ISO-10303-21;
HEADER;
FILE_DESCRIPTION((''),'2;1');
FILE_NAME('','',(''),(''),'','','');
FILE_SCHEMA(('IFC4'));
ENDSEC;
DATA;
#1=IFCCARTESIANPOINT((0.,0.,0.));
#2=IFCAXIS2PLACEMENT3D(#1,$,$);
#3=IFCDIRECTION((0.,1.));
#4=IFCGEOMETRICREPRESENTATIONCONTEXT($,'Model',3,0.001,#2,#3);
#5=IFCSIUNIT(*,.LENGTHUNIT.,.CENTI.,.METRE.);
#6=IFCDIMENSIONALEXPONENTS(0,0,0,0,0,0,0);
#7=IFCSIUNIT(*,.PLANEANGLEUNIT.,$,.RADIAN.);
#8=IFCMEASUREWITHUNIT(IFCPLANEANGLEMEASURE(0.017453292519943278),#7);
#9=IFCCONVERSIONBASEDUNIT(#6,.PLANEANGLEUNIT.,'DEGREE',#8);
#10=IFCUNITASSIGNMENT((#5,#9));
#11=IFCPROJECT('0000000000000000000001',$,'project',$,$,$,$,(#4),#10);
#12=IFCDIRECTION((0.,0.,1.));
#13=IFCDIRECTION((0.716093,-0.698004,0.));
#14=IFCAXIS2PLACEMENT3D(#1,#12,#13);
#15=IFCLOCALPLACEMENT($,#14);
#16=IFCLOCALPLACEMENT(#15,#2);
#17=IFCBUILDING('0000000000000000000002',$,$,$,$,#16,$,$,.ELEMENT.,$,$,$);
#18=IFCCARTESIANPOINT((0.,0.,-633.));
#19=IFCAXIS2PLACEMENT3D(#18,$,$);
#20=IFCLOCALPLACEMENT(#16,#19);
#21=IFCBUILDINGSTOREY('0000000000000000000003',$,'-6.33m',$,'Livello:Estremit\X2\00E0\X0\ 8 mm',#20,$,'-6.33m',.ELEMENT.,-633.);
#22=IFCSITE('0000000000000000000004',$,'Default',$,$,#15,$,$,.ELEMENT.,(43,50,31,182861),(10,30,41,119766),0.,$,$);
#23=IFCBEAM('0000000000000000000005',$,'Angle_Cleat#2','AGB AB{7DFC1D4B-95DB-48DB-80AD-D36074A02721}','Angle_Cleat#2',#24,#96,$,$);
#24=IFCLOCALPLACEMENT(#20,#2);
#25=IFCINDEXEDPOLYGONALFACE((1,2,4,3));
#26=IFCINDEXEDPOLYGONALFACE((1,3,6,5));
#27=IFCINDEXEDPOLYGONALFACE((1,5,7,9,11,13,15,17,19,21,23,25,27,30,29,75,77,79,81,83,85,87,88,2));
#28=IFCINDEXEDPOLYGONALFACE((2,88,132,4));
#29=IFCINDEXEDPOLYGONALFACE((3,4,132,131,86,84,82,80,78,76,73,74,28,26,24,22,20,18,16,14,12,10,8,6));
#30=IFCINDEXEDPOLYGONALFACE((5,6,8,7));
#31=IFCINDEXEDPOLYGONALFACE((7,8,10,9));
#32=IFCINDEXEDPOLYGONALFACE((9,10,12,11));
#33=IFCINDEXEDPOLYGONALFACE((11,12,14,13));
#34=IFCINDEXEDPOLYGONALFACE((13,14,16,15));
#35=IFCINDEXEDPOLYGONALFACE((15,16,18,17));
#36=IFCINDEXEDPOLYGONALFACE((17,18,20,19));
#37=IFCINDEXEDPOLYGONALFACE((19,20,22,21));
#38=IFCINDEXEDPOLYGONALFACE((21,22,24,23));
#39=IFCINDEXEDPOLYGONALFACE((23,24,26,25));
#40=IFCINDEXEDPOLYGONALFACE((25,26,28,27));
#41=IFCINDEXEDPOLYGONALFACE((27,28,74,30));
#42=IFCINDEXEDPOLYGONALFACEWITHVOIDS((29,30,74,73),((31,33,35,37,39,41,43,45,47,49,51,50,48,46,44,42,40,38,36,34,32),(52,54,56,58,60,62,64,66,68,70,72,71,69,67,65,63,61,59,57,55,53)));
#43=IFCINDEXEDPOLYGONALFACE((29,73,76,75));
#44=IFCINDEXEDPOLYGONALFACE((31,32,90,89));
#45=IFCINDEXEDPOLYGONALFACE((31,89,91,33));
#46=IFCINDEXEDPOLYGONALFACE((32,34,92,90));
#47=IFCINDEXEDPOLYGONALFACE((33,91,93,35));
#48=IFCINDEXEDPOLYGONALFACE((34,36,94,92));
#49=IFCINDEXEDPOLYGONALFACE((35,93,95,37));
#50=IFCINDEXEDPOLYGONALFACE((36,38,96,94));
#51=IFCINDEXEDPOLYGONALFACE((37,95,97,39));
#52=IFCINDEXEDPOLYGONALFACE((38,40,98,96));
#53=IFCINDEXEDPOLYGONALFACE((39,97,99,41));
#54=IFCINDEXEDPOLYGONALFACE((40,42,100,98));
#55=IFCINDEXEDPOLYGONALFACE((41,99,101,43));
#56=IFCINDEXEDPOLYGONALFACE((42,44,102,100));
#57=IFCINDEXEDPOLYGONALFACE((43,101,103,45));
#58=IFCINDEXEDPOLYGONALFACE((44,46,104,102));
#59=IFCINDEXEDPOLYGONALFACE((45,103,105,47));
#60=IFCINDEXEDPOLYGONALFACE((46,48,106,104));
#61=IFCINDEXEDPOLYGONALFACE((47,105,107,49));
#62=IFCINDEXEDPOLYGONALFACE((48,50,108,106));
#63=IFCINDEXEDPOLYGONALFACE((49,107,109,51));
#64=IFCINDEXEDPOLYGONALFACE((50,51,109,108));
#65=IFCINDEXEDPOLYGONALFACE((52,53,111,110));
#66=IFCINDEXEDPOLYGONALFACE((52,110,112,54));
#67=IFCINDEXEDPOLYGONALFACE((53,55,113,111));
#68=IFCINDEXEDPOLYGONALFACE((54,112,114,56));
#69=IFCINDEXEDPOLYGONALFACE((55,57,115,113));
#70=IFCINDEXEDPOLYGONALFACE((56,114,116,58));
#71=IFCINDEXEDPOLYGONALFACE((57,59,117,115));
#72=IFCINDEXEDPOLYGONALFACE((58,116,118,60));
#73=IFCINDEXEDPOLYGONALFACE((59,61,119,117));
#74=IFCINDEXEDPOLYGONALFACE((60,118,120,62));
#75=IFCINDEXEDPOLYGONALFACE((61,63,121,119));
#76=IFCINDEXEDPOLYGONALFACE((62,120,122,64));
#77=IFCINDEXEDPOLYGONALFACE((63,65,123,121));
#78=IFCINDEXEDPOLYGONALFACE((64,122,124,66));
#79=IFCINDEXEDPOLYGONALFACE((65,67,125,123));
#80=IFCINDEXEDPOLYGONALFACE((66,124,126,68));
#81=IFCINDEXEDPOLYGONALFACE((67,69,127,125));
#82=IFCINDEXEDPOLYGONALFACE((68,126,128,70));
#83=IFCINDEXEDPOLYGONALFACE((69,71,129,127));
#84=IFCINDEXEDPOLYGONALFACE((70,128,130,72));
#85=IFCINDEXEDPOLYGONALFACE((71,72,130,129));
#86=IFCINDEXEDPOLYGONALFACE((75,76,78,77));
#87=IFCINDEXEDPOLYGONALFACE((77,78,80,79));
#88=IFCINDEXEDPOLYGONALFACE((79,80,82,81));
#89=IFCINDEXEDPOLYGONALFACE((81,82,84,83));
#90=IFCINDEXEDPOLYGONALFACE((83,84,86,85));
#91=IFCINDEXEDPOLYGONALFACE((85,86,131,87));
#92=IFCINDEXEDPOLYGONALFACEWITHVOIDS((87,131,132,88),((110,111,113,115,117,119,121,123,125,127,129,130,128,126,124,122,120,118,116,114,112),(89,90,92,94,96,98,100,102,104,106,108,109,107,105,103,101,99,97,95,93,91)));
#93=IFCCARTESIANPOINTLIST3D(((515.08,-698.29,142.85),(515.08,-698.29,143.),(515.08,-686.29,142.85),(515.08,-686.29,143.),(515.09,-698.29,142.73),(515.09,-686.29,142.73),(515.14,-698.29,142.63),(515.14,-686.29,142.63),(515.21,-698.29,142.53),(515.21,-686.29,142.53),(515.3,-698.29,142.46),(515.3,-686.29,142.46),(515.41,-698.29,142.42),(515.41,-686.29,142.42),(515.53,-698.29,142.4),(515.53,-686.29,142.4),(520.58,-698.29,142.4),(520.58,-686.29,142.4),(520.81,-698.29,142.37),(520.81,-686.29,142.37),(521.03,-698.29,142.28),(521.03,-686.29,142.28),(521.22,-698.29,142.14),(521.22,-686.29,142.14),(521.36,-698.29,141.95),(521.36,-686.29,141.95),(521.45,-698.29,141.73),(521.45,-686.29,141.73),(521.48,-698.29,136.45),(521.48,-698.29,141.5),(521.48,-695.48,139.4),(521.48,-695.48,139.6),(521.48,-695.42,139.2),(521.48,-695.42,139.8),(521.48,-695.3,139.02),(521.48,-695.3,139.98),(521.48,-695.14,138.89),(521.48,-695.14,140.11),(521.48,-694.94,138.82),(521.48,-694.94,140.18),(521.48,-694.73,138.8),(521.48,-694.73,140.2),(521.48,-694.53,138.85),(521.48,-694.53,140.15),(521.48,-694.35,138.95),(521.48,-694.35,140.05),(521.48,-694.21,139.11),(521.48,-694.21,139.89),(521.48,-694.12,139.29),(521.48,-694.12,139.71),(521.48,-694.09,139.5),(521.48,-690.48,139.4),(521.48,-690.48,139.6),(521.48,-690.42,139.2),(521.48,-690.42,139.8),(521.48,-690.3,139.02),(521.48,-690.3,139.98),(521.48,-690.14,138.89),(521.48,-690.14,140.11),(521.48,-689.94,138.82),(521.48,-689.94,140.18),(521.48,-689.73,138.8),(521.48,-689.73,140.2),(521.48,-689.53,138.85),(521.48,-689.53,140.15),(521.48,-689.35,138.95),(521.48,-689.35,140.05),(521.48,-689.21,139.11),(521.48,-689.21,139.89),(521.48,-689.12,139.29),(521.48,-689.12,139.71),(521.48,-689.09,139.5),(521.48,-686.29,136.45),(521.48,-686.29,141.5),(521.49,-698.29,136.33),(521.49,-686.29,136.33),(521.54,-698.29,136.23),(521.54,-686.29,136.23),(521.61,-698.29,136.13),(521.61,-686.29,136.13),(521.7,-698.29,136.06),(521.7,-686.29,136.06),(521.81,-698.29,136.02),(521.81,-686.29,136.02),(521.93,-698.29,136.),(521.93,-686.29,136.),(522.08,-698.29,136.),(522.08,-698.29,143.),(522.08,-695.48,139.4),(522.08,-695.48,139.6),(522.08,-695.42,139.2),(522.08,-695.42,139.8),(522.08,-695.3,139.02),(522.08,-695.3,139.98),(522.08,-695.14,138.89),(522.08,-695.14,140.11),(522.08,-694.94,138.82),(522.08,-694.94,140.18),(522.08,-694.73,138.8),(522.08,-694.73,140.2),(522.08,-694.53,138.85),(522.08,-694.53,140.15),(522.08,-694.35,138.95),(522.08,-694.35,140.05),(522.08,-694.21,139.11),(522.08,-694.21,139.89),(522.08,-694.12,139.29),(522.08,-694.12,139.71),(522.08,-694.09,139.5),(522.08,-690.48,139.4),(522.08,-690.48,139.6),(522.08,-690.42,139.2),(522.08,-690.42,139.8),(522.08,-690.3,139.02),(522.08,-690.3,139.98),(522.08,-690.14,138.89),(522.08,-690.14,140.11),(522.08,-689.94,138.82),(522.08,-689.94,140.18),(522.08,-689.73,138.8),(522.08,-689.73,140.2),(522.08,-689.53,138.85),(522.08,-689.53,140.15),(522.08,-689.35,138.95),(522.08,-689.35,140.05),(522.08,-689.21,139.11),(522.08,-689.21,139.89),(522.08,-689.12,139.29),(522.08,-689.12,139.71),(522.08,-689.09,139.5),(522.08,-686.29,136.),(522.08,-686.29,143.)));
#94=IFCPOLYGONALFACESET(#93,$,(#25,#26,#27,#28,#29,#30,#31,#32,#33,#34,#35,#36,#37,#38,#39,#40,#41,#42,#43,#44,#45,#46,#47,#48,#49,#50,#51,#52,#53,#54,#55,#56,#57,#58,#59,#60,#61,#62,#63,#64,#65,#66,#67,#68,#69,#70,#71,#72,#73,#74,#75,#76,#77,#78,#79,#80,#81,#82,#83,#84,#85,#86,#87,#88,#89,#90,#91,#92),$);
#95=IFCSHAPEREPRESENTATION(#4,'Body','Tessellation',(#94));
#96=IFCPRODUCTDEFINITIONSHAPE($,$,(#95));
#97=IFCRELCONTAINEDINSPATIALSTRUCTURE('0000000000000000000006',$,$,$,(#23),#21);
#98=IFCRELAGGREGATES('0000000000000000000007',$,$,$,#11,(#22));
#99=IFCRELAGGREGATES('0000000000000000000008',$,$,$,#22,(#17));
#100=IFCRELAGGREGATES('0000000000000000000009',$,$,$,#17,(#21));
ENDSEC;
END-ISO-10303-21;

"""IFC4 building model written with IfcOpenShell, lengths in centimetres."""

from ifc_helpers import new_model, entity, si_unit, converted_unit, direction, frame, frame_2d, origin, place, context, project, spatial, circle, l_section, extrude, element, save


model = new_model("IFC4")

# Units and contexts
model_context = context("Model", 3, precision=0.001, world=origin(), true_north=direction((0.0, 1.0)))
ifc_project = project(units=[si_unit("LENGTHUNIT", "METRE", prefix="CENTI"), converted_unit("PLANEANGLEUNIT", "DEGREE", entity("IfcPlaneAngleMeasure", 0.017453292519943278), si_unit("PLANEANGLEUNIT", "RADIAN"), dimensions=[0, 0, 0, 0, 0, 0, 0])], contexts=[model_context])

# Site, building, storey
site_placement = place(None, frame((0.0, 0.0, 0.0), z_axis=(0.0, 0.0, 1.0), x_axis=(0.716093, -0.698004, 0.0)))
site = spatial("IfcSite", under=ifc_project, at=site_placement, Name="Default", CompositionType="ELEMENT", RefLatitude=(43, 50, 31, 182861), RefLongitude=(10, 30, 41, 119766), RefElevation=0.0)
building_placement = place(site_placement, origin())
building = spatial("IfcBuilding", under=site, at=building_placement, CompositionType="ELEMENT")
storey_placement = place(building_placement, frame((0.0, 0.0, -633.0)))
storey = spatial("IfcBuildingStorey", under=building, at=storey_placement, Name="-6.33m", ObjectType="Livello:Estremità 8 mm", LongName="-6.33m", CompositionType="ELEMENT", Elevation=-633.0)

# Beam, openings
beam_1_placement = place(storey_placement, frame((520.15, -698.29, 141.07), z_axis=(0.0, -1.0, 0.0), x_axis=(-1.0, 0.0, 0.0)))
beam_1 = element("IfcBeam", 1, at=beam_1_placement, inside=storey, Name="Angle_Cleat#2", Description="AGB AB{7DFC1D4B-95DB-48DB-80AD-D36074A02721}", ObjectType="Angle_Cleat#2", context=model_context, shape_type="SweptSolid", body=[
    extrude(l_section(Depth=7.0, Width=7.0, Thickness=0.6, FilletRadius=0.9, EdgeRadius=0.45, at=frame_2d((1.57, 1.57))), origin(), (0.0, 0.0, -1.0), 12.0),
])
opening_1_placement = place(beam_1_placement, frame((-1.28, 1.57, -6.0), z_axis=(-1.0, 0.0, 0.0), x_axis=(0.0, 0.0, -1.0)))
element("IfcOpeningElement", 2, at=opening_1_placement, cuts=beam_1, ObjectType="Opening", context=model_context, shape_type="SweptSolid", body=[
    extrude(circle(Radius=0.7, at=frame_2d((2.5, 0.0), x_axis=(1.0, 0.0))), origin(), (0.0, 0.0, 1.0), 0.7),
])
opening_2_placement = place(beam_1_placement, frame((-1.28, 1.57, -6.0), z_axis=(-1.0, 0.0, 0.0), x_axis=(0.0, 0.0, -1.0)))
element("IfcOpeningElement", 3, at=opening_2_placement, cuts=beam_1, ObjectType="Opening", context=model_context, shape_type="SweptSolid", body=[
    extrude(circle(Radius=0.7, at=frame_2d((-2.5, 0.0), x_axis=(1.0, 0.0))), origin(), (0.0, 0.0, 1.0), 0.7),
])

save(model, "model.ifc")
